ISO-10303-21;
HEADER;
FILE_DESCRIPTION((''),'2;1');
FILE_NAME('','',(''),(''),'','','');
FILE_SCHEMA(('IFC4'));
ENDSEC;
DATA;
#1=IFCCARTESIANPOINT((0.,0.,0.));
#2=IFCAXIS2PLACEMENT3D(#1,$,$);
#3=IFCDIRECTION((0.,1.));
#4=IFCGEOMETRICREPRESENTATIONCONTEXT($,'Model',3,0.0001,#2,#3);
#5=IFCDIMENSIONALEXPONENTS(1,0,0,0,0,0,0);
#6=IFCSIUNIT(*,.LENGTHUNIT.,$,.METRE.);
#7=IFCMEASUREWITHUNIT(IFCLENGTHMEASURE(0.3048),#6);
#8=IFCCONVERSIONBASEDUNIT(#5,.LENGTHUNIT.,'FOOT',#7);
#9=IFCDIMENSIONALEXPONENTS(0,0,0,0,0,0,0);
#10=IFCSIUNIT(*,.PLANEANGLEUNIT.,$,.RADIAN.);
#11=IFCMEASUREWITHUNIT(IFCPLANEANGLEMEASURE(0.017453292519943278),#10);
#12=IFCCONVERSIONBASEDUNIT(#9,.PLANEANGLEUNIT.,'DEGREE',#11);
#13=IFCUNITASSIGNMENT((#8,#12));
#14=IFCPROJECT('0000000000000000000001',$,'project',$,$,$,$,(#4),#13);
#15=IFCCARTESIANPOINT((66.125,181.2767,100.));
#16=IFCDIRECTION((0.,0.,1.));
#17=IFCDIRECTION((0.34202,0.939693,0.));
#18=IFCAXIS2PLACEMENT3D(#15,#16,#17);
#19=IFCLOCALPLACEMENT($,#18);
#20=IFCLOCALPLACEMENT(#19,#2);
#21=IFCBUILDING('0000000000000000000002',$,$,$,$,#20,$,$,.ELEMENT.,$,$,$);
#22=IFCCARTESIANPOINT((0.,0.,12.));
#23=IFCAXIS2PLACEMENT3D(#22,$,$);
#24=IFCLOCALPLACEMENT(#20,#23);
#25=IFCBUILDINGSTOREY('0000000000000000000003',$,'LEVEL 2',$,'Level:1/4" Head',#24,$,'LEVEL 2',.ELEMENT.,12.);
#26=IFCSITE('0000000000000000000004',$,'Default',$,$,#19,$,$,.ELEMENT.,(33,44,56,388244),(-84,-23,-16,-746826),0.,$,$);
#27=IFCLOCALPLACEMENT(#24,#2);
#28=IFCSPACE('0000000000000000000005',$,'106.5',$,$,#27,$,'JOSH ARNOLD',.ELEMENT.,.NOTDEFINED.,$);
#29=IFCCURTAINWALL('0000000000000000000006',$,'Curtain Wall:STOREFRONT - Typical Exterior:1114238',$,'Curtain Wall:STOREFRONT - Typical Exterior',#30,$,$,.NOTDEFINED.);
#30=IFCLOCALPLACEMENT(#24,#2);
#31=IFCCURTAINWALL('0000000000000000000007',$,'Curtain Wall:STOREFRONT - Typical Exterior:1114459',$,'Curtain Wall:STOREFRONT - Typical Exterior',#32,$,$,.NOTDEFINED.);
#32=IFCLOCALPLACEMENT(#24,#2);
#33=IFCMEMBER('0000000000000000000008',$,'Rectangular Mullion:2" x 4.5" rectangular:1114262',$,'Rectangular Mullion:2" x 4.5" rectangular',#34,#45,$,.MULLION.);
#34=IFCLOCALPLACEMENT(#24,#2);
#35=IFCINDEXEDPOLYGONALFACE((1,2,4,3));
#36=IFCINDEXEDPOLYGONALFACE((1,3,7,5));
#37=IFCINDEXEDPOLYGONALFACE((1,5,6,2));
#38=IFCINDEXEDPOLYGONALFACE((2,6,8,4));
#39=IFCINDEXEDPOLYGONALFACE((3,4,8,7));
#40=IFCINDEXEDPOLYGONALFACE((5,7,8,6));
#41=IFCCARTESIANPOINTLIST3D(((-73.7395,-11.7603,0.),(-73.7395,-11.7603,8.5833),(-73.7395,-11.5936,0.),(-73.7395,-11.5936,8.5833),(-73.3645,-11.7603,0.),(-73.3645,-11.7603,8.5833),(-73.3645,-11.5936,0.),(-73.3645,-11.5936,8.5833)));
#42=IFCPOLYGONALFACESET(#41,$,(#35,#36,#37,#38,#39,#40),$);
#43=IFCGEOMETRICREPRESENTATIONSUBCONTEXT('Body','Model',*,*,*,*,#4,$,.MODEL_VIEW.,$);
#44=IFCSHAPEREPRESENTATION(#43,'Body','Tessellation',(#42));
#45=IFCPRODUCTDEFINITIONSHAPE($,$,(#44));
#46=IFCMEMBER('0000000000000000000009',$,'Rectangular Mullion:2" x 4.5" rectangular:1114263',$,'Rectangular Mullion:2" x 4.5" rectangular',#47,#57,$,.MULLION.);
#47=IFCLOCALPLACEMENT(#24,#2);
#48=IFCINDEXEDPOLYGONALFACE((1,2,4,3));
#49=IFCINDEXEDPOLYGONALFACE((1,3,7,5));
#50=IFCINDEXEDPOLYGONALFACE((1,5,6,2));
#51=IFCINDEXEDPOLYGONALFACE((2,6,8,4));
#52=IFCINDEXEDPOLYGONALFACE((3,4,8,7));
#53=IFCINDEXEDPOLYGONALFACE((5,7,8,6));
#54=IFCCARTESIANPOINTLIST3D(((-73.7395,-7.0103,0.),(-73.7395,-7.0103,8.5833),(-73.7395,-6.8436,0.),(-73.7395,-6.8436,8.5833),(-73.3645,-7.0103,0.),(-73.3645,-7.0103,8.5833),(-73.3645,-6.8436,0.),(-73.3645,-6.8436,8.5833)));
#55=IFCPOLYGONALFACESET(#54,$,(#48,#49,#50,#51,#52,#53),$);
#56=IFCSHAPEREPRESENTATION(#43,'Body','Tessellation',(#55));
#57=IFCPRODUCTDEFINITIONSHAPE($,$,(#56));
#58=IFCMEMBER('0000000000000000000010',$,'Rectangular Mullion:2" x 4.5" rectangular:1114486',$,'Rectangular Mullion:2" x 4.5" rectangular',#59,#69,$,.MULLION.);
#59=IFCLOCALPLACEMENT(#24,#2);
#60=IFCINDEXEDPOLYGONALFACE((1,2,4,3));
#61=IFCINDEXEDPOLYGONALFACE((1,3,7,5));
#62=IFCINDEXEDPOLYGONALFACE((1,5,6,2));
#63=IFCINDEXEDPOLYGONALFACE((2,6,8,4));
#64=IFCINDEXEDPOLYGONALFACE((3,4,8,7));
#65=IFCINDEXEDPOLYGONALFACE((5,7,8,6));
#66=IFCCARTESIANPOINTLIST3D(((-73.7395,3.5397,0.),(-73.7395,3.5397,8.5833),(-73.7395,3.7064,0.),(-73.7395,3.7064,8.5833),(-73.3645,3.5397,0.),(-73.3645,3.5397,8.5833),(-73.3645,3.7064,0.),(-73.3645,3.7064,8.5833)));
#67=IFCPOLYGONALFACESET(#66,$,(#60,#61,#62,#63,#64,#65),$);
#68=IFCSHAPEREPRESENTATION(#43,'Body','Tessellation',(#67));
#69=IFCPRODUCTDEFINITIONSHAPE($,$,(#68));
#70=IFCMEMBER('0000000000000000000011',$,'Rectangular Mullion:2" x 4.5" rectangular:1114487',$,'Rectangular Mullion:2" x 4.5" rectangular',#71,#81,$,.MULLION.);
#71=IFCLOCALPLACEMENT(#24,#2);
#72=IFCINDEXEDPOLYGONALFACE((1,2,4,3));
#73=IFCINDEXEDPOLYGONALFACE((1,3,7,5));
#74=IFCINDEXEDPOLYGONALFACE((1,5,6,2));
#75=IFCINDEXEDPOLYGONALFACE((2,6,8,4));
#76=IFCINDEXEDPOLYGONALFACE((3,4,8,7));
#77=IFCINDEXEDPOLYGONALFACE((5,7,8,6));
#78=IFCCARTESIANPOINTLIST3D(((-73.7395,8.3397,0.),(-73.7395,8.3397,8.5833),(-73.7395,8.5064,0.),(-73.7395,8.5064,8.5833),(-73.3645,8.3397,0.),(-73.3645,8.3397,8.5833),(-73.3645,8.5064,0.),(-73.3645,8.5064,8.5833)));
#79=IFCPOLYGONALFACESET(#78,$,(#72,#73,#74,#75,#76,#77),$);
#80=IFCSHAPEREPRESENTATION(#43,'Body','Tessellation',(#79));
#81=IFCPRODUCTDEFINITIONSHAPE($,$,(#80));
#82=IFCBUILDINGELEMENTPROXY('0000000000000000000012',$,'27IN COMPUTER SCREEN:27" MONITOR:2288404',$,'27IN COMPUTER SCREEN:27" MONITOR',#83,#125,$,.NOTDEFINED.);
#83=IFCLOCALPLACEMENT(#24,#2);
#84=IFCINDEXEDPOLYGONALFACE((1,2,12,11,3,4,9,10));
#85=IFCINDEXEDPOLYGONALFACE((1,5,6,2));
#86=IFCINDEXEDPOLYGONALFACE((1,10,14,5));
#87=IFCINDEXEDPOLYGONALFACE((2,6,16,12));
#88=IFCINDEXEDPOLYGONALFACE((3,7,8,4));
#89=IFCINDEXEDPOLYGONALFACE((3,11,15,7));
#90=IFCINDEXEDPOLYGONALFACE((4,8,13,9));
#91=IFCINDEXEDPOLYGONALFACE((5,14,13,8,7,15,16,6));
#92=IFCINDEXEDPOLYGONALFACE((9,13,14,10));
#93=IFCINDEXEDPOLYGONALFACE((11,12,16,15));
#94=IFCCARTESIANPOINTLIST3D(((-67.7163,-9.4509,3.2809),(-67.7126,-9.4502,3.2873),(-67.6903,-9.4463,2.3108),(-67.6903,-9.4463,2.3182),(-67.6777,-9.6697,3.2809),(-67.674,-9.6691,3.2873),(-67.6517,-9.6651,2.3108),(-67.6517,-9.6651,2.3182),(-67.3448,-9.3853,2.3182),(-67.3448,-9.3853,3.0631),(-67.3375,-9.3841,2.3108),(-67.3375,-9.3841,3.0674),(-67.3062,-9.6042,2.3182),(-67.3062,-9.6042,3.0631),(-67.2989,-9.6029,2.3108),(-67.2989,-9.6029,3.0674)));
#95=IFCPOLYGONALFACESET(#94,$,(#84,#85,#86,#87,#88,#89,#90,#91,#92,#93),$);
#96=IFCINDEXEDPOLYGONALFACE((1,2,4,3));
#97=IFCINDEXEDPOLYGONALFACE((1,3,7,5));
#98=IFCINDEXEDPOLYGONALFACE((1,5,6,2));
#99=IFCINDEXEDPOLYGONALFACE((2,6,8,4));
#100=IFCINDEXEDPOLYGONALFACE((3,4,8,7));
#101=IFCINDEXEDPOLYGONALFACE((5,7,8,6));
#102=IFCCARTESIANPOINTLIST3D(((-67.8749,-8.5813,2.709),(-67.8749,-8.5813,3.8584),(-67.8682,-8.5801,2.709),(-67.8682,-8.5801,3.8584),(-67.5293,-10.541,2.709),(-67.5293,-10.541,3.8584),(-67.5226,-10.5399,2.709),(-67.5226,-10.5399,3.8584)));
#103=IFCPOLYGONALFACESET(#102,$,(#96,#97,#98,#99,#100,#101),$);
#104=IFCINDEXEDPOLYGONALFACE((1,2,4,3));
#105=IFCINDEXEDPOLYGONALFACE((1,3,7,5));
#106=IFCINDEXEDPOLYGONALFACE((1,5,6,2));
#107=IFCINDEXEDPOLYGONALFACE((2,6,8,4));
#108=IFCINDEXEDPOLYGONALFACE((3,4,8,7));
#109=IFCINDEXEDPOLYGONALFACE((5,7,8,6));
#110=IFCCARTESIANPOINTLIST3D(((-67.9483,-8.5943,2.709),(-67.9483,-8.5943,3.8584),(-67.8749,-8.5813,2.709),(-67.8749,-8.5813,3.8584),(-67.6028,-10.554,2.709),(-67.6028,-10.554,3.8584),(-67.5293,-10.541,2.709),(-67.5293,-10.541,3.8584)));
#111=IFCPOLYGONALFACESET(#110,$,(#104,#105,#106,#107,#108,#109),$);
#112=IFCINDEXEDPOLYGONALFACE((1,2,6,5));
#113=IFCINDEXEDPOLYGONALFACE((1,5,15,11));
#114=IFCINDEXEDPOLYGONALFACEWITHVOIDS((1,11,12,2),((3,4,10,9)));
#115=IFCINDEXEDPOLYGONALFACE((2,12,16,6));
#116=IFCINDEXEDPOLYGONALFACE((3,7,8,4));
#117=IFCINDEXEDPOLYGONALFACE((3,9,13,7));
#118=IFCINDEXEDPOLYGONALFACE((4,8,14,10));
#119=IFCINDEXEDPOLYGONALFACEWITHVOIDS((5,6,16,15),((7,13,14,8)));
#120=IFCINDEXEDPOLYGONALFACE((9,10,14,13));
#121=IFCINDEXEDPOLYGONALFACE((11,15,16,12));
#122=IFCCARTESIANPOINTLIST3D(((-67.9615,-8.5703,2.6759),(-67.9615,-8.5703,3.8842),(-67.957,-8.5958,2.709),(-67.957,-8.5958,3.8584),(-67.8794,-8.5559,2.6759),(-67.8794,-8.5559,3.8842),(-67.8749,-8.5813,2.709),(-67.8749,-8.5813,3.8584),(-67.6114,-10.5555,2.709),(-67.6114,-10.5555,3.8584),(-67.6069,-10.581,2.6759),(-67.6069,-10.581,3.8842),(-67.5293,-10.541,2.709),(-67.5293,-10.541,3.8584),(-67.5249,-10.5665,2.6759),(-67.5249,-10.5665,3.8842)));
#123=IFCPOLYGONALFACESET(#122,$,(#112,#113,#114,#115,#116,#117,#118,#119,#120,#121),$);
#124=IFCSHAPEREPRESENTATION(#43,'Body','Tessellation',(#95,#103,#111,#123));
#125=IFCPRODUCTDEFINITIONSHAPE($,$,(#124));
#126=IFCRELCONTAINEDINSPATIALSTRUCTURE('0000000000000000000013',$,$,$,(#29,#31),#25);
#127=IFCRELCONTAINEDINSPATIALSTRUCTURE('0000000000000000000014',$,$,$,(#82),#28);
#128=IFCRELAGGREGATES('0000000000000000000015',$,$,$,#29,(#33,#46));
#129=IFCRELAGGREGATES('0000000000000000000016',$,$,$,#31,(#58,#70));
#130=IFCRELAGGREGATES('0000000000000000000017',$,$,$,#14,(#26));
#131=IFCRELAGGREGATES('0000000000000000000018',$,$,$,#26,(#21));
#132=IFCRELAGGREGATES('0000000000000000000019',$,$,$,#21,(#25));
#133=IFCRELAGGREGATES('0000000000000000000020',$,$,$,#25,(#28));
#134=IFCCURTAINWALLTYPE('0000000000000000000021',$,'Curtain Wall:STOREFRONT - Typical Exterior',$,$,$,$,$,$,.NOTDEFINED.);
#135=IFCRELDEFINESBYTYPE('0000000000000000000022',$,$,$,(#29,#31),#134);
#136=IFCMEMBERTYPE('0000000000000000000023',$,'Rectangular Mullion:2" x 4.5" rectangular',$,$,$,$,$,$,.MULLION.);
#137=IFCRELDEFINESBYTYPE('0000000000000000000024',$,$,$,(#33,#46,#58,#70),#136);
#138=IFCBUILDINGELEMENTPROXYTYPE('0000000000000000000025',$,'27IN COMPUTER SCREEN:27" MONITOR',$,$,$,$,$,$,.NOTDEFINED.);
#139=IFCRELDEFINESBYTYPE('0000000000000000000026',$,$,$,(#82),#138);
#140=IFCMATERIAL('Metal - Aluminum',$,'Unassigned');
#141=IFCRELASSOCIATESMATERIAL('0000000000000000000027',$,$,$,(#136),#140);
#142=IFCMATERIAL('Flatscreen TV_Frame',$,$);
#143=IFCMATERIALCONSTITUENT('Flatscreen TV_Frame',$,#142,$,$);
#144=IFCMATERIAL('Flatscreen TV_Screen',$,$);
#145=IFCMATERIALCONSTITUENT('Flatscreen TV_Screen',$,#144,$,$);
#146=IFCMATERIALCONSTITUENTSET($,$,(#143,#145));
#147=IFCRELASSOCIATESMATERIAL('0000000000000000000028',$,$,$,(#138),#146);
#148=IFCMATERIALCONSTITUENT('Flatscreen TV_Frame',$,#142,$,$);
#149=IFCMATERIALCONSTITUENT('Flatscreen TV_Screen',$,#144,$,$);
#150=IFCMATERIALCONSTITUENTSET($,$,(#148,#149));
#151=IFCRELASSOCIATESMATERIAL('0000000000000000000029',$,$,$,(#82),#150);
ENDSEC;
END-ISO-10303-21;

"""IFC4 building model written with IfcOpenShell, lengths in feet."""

from ifc_helpers import new_model, entity, si_unit, converted_unit, direction, frame, frame_2d, origin, origin_2d_with_axis, place, context, subcontext, project, spatial, polyline, rectangle, outline, extrude, source, transform, mapped, material, constituent, constituent_set, material_profile, profile_set, type_object, type_shapes, element, aggregate, save


model = new_model("IFC4")

# Units and contexts
model_context = context("Model", 3, precision=0.0001, world=origin(), true_north=direction((0.0, 1.0)))
body_context = subcontext(model_context, "Body", "Model", "MODEL_VIEW")
ifc_project = project(units=[converted_unit("LENGTHUNIT", "FOOT", entity("IfcLengthMeasure", 0.3048), si_unit("LENGTHUNIT", "METRE"), dimensions=[1, 0, 0, 0, 0, 0, 0]), converted_unit("PLANEANGLEUNIT", "DEGREE", entity("IfcPlaneAngleMeasure", 0.017453292519943278), si_unit("PLANEANGLEUNIT", "RADIAN"), dimensions=[0, 0, 0, 0, 0, 0, 0])], contexts=[model_context])

# Site, building, storey
site_placement = place(None, frame((66.125, 181.2767, 100.0), z_axis=(0.0, 0.0, 1.0), x_axis=(0.34202, 0.939693, 0.0)))
site = spatial("IfcSite", under=ifc_project, at=site_placement, Name="Default", CompositionType="ELEMENT", RefLatitude=(33, 44, 56, 388244), RefLongitude=(-84, -23, -16, -746826), RefElevation=0.0)
building_placement = place(site_placement, origin())
building = spatial("IfcBuilding", under=site, at=building_placement, CompositionType="ELEMENT")
storey_placement = place(building_placement, frame((0.0, 0.0, 12.0)))
storey = spatial("IfcBuildingStorey", under=building, at=storey_placement, Name="LEVEL 2", ObjectType="Level:1/4\" Head", LongName="LEVEL 2", CompositionType="ELEMENT", Elevation=12.0)

# Curtain walls
curtain_wall_type = type_object("IfcCurtainWallType", Name="Curtain Wall:STOREFRONT - Typical Exterior", PredefinedType="NOTDEFINED")
curtain_wall_1_placement = place(storey_placement, frame((0.0, 0.0, -12.0)))
curtain_wall_1 = element("IfcCurtainWall", 1, at=curtain_wall_1_placement, inside=storey, type_object=curtain_wall_type, Name="Curtain Wall:STOREFRONT - Typical Exterior:1114238", ObjectType="Curtain Wall:STOREFRONT - Typical Exterior", PredefinedType="NOTDEFINED")
ifc_material_1 = material(Name="Metal - Aluminum", Category="Unassigned")
ifc_material_profile = material_profile(ifc_material_1, rectangle(XDim=0.1667, YDim=0.375, at=origin_2d_with_axis()), Name="2\" x 4.5\" rectangular")
ifc_profile_set = profile_set([ifc_material_profile], Name="2\" x 4.5\" rectangular")
curtain_wall_2_placement = place(storey_placement, frame((0.0, 0.0, -12.0)))
curtain_wall_2 = element("IfcCurtainWall", 2, at=curtain_wall_2_placement, inside=storey, type_object=curtain_wall_type, Name="Curtain Wall:STOREFRONT - Typical Exterior:1114459", ObjectType="Curtain Wall:STOREFRONT - Typical Exterior", PredefinedType="NOTDEFINED")

# Members
member_type_1 = type_object("IfcMemberType", Name="Rectangular Mullion:2\" x 4.5\" rectangular", PredefinedType="MULLION", material=ifc_profile_set)
shared_shape_1 = source(origin(), body_context, "Body", "SweptSolid", [
    extrude(rectangle(XDim=0.1667, YDim=0.375, at=frame_2d((0.0, 0.0), x_axis=(1.0, 0.0))), frame((0.0, 0.0, -8.5833), z_axis=(0.0, 0.0, 1.0), x_axis=(-1.0, 0.0, 0.0)), (0.0, 0.0, 1.0), 8.5833),
])
type_shapes(member_type_1, [shared_shape_1])
member_1_placement = place(curtain_wall_1_placement, frame((-73.552, -11.677, 12.0), z_axis=(0.0, 0.0, -1.0), x_axis=(0.0, 1.0, 0.0)))
member_1 = element("IfcMember", 3, at=member_1_placement, type_object=member_type_1, Name="Rectangular Mullion:2\" x 4.5\" rectangular:1114262", ObjectType="Rectangular Mullion:2\" x 4.5\" rectangular", PredefinedType="MULLION", context=body_context, shape_type="MappedRepresentation", body=[
    mapped(shared_shape_1, transform((0.0, 0.0, 0.0), scale=1.0)),
])
member_2_placement = place(curtain_wall_1_placement, frame((-73.552, -6.927, 12.0), z_axis=(0.0, 0.0, -1.0), x_axis=(0.0, 1.0, 0.0)))
member_2 = element("IfcMember", 4, at=member_2_placement, type_object=member_type_1, Name="Rectangular Mullion:2\" x 4.5\" rectangular:1114263", ObjectType="Rectangular Mullion:2\" x 4.5\" rectangular", PredefinedType="MULLION", context=body_context, shape_type="MappedRepresentation", body=[
    mapped(shared_shape_1, transform((0.0, 0.0, 0.0), scale=1.0)),
])
member_3_placement = place(curtain_wall_2_placement, frame((-73.552, 3.623, 12.0), z_axis=(0.0, 0.0, -1.0), x_axis=(0.0, 1.0, 0.0)))
member_3 = element("IfcMember", 5, at=member_3_placement, type_object=member_type_1, Name="Rectangular Mullion:2\" x 4.5\" rectangular:1114486", ObjectType="Rectangular Mullion:2\" x 4.5\" rectangular", PredefinedType="MULLION", context=body_context, shape_type="MappedRepresentation", body=[
    mapped(shared_shape_1, transform((0.0, 0.0, 0.0), scale=1.0)),
])
member_4_placement = place(curtain_wall_2_placement, frame((-73.552, 8.423, 12.0), z_axis=(0.0, 0.0, -1.0), x_axis=(0.0, 1.0, 0.0)))
member_4 = element("IfcMember", 6, at=member_4_placement, type_object=member_type_1, Name="Rectangular Mullion:2\" x 4.5\" rectangular:1114487", ObjectType="Rectangular Mullion:2\" x 4.5\" rectangular", PredefinedType="MULLION", context=body_context, shape_type="MappedRepresentation", body=[
    mapped(shared_shape_1, transform((0.0, 0.0, 0.0), scale=1.0)),
])

aggregate(curtain_wall_1, [member_1, member_2])
aggregate(curtain_wall_2, [member_3, member_4])

# Shared definitions
space_placement = place(storey_placement, origin())
space = spatial("IfcSpace", under=storey, at=space_placement, Name="106.5", LongName="JOSH ARNOLD", CompositionType="ELEMENT", PredefinedType="NOTDEFINED")

# Building element proxy
ifc_material_2 = material(Name="Flatscreen TV_Frame")
ifc_constituent_1 = constituent(ifc_material_2, Name="Flatscreen TV_Frame")
ifc_material_3 = material(Name="Flatscreen TV_Screen")
ifc_constituent_2 = constituent(ifc_material_3, Name="Flatscreen TV_Screen")
ifc_constituent_set_1 = constituent_set(constituents=[ifc_constituent_1, ifc_constituent_2])
ifc_constituent_3 = constituent(ifc_material_2, Name="Flatscreen TV_Frame")
ifc_constituent_4 = constituent(ifc_material_3, Name="Flatscreen TV_Screen")
ifc_constituent_set_2 = constituent_set(constituents=[ifc_constituent_3, ifc_constituent_4])
building_element_proxy_type = type_object("IfcBuildingElementProxyType", Name="27IN COMPUTER SCREEN:27\" MONITOR", PredefinedType="NOTDEFINED", material=ifc_constituent_set_2)
shared_shape_2 = source(origin(), body_context, "Body", "SweptSolid", [
    extrude(outline(polyline([(0.3657, -0.4392), (0.3731, -0.4392), (0.3731, 0.0007), (-0.2821, 0.379), (-0.4613, 0.0686), (-0.4548, 0.0649), (-0.2794, 0.3688), (0.3657, -0.0036), (0.3657, -0.4392)])), frame((-0.1111, 0.0264, 0.0687), z_axis=(1.0, 0.0, 0.0), x_axis=(0.0, -0.5, 0.866025)), (0.0, 0.0, 1.0), 0.2222),
    extrude(rectangle(XDim=1.9899, YDim=0.0068, at=origin_2d_with_axis()), frame((0.0, 0.2257, 0.0331), z_axis=(0.0, 0.0, 1.0), x_axis=(-1.0, 0.0, 0.0)), (0.0, 0.0, 1.0), 1.1493),
    extrude(rectangle(XDim=1.9899, YDim=0.0746, at=frame_2d((0.0, 0.0), x_axis=(1.0, 0.0))), frame((0.0, 0.2664, 0.0331), z_axis=(0.0, 0.0, 1.0), x_axis=(-1.0, 0.0, 0.0)), (0.0, 0.0, 1.0), 1.1493),
    extrude(outline(polyline([(-0.6042, -1.0208), (0.6042, -1.0208), (0.6042, 1.0208), (-0.6042, 1.0208), (-0.6042, -1.0208)]), holes=[polyline([(-0.5783, -0.995), (-0.5783, 0.995), (0.571, 0.995), (0.571, -0.995), (-0.5783, -0.995)])]), frame((0.0, 0.2292, 0.6042), z_axis=(0.0, 1.0, 0.0), x_axis=(0.0, 0.0, -1.0)), (0.0, 0.0, 1.0), 0.0833),
])
type_shapes(building_element_proxy_type, [shared_shape_2])
proxy_placement = place(space_placement, frame((-67.4764, -9.5214, 2.6759), z_axis=(0.0, 0.0, 1.0), x_axis=(-0.173648, 0.984808, 0.0)))
element("IfcBuildingElementProxy", 7, at=proxy_placement, inside=space, type_object=building_element_proxy_type, material=ifc_constituent_set_1, Name="27IN COMPUTER SCREEN:27\" MONITOR:2288404", ObjectType="27IN COMPUTER SCREEN:27\" MONITOR", PredefinedType="NOTDEFINED", context=body_context, shape_type="MappedRepresentation", body=[
    mapped(shared_shape_2, transform((0.0, 0.0, 0.0), scale=1.0)),
])

save(model, "model.ifc")
